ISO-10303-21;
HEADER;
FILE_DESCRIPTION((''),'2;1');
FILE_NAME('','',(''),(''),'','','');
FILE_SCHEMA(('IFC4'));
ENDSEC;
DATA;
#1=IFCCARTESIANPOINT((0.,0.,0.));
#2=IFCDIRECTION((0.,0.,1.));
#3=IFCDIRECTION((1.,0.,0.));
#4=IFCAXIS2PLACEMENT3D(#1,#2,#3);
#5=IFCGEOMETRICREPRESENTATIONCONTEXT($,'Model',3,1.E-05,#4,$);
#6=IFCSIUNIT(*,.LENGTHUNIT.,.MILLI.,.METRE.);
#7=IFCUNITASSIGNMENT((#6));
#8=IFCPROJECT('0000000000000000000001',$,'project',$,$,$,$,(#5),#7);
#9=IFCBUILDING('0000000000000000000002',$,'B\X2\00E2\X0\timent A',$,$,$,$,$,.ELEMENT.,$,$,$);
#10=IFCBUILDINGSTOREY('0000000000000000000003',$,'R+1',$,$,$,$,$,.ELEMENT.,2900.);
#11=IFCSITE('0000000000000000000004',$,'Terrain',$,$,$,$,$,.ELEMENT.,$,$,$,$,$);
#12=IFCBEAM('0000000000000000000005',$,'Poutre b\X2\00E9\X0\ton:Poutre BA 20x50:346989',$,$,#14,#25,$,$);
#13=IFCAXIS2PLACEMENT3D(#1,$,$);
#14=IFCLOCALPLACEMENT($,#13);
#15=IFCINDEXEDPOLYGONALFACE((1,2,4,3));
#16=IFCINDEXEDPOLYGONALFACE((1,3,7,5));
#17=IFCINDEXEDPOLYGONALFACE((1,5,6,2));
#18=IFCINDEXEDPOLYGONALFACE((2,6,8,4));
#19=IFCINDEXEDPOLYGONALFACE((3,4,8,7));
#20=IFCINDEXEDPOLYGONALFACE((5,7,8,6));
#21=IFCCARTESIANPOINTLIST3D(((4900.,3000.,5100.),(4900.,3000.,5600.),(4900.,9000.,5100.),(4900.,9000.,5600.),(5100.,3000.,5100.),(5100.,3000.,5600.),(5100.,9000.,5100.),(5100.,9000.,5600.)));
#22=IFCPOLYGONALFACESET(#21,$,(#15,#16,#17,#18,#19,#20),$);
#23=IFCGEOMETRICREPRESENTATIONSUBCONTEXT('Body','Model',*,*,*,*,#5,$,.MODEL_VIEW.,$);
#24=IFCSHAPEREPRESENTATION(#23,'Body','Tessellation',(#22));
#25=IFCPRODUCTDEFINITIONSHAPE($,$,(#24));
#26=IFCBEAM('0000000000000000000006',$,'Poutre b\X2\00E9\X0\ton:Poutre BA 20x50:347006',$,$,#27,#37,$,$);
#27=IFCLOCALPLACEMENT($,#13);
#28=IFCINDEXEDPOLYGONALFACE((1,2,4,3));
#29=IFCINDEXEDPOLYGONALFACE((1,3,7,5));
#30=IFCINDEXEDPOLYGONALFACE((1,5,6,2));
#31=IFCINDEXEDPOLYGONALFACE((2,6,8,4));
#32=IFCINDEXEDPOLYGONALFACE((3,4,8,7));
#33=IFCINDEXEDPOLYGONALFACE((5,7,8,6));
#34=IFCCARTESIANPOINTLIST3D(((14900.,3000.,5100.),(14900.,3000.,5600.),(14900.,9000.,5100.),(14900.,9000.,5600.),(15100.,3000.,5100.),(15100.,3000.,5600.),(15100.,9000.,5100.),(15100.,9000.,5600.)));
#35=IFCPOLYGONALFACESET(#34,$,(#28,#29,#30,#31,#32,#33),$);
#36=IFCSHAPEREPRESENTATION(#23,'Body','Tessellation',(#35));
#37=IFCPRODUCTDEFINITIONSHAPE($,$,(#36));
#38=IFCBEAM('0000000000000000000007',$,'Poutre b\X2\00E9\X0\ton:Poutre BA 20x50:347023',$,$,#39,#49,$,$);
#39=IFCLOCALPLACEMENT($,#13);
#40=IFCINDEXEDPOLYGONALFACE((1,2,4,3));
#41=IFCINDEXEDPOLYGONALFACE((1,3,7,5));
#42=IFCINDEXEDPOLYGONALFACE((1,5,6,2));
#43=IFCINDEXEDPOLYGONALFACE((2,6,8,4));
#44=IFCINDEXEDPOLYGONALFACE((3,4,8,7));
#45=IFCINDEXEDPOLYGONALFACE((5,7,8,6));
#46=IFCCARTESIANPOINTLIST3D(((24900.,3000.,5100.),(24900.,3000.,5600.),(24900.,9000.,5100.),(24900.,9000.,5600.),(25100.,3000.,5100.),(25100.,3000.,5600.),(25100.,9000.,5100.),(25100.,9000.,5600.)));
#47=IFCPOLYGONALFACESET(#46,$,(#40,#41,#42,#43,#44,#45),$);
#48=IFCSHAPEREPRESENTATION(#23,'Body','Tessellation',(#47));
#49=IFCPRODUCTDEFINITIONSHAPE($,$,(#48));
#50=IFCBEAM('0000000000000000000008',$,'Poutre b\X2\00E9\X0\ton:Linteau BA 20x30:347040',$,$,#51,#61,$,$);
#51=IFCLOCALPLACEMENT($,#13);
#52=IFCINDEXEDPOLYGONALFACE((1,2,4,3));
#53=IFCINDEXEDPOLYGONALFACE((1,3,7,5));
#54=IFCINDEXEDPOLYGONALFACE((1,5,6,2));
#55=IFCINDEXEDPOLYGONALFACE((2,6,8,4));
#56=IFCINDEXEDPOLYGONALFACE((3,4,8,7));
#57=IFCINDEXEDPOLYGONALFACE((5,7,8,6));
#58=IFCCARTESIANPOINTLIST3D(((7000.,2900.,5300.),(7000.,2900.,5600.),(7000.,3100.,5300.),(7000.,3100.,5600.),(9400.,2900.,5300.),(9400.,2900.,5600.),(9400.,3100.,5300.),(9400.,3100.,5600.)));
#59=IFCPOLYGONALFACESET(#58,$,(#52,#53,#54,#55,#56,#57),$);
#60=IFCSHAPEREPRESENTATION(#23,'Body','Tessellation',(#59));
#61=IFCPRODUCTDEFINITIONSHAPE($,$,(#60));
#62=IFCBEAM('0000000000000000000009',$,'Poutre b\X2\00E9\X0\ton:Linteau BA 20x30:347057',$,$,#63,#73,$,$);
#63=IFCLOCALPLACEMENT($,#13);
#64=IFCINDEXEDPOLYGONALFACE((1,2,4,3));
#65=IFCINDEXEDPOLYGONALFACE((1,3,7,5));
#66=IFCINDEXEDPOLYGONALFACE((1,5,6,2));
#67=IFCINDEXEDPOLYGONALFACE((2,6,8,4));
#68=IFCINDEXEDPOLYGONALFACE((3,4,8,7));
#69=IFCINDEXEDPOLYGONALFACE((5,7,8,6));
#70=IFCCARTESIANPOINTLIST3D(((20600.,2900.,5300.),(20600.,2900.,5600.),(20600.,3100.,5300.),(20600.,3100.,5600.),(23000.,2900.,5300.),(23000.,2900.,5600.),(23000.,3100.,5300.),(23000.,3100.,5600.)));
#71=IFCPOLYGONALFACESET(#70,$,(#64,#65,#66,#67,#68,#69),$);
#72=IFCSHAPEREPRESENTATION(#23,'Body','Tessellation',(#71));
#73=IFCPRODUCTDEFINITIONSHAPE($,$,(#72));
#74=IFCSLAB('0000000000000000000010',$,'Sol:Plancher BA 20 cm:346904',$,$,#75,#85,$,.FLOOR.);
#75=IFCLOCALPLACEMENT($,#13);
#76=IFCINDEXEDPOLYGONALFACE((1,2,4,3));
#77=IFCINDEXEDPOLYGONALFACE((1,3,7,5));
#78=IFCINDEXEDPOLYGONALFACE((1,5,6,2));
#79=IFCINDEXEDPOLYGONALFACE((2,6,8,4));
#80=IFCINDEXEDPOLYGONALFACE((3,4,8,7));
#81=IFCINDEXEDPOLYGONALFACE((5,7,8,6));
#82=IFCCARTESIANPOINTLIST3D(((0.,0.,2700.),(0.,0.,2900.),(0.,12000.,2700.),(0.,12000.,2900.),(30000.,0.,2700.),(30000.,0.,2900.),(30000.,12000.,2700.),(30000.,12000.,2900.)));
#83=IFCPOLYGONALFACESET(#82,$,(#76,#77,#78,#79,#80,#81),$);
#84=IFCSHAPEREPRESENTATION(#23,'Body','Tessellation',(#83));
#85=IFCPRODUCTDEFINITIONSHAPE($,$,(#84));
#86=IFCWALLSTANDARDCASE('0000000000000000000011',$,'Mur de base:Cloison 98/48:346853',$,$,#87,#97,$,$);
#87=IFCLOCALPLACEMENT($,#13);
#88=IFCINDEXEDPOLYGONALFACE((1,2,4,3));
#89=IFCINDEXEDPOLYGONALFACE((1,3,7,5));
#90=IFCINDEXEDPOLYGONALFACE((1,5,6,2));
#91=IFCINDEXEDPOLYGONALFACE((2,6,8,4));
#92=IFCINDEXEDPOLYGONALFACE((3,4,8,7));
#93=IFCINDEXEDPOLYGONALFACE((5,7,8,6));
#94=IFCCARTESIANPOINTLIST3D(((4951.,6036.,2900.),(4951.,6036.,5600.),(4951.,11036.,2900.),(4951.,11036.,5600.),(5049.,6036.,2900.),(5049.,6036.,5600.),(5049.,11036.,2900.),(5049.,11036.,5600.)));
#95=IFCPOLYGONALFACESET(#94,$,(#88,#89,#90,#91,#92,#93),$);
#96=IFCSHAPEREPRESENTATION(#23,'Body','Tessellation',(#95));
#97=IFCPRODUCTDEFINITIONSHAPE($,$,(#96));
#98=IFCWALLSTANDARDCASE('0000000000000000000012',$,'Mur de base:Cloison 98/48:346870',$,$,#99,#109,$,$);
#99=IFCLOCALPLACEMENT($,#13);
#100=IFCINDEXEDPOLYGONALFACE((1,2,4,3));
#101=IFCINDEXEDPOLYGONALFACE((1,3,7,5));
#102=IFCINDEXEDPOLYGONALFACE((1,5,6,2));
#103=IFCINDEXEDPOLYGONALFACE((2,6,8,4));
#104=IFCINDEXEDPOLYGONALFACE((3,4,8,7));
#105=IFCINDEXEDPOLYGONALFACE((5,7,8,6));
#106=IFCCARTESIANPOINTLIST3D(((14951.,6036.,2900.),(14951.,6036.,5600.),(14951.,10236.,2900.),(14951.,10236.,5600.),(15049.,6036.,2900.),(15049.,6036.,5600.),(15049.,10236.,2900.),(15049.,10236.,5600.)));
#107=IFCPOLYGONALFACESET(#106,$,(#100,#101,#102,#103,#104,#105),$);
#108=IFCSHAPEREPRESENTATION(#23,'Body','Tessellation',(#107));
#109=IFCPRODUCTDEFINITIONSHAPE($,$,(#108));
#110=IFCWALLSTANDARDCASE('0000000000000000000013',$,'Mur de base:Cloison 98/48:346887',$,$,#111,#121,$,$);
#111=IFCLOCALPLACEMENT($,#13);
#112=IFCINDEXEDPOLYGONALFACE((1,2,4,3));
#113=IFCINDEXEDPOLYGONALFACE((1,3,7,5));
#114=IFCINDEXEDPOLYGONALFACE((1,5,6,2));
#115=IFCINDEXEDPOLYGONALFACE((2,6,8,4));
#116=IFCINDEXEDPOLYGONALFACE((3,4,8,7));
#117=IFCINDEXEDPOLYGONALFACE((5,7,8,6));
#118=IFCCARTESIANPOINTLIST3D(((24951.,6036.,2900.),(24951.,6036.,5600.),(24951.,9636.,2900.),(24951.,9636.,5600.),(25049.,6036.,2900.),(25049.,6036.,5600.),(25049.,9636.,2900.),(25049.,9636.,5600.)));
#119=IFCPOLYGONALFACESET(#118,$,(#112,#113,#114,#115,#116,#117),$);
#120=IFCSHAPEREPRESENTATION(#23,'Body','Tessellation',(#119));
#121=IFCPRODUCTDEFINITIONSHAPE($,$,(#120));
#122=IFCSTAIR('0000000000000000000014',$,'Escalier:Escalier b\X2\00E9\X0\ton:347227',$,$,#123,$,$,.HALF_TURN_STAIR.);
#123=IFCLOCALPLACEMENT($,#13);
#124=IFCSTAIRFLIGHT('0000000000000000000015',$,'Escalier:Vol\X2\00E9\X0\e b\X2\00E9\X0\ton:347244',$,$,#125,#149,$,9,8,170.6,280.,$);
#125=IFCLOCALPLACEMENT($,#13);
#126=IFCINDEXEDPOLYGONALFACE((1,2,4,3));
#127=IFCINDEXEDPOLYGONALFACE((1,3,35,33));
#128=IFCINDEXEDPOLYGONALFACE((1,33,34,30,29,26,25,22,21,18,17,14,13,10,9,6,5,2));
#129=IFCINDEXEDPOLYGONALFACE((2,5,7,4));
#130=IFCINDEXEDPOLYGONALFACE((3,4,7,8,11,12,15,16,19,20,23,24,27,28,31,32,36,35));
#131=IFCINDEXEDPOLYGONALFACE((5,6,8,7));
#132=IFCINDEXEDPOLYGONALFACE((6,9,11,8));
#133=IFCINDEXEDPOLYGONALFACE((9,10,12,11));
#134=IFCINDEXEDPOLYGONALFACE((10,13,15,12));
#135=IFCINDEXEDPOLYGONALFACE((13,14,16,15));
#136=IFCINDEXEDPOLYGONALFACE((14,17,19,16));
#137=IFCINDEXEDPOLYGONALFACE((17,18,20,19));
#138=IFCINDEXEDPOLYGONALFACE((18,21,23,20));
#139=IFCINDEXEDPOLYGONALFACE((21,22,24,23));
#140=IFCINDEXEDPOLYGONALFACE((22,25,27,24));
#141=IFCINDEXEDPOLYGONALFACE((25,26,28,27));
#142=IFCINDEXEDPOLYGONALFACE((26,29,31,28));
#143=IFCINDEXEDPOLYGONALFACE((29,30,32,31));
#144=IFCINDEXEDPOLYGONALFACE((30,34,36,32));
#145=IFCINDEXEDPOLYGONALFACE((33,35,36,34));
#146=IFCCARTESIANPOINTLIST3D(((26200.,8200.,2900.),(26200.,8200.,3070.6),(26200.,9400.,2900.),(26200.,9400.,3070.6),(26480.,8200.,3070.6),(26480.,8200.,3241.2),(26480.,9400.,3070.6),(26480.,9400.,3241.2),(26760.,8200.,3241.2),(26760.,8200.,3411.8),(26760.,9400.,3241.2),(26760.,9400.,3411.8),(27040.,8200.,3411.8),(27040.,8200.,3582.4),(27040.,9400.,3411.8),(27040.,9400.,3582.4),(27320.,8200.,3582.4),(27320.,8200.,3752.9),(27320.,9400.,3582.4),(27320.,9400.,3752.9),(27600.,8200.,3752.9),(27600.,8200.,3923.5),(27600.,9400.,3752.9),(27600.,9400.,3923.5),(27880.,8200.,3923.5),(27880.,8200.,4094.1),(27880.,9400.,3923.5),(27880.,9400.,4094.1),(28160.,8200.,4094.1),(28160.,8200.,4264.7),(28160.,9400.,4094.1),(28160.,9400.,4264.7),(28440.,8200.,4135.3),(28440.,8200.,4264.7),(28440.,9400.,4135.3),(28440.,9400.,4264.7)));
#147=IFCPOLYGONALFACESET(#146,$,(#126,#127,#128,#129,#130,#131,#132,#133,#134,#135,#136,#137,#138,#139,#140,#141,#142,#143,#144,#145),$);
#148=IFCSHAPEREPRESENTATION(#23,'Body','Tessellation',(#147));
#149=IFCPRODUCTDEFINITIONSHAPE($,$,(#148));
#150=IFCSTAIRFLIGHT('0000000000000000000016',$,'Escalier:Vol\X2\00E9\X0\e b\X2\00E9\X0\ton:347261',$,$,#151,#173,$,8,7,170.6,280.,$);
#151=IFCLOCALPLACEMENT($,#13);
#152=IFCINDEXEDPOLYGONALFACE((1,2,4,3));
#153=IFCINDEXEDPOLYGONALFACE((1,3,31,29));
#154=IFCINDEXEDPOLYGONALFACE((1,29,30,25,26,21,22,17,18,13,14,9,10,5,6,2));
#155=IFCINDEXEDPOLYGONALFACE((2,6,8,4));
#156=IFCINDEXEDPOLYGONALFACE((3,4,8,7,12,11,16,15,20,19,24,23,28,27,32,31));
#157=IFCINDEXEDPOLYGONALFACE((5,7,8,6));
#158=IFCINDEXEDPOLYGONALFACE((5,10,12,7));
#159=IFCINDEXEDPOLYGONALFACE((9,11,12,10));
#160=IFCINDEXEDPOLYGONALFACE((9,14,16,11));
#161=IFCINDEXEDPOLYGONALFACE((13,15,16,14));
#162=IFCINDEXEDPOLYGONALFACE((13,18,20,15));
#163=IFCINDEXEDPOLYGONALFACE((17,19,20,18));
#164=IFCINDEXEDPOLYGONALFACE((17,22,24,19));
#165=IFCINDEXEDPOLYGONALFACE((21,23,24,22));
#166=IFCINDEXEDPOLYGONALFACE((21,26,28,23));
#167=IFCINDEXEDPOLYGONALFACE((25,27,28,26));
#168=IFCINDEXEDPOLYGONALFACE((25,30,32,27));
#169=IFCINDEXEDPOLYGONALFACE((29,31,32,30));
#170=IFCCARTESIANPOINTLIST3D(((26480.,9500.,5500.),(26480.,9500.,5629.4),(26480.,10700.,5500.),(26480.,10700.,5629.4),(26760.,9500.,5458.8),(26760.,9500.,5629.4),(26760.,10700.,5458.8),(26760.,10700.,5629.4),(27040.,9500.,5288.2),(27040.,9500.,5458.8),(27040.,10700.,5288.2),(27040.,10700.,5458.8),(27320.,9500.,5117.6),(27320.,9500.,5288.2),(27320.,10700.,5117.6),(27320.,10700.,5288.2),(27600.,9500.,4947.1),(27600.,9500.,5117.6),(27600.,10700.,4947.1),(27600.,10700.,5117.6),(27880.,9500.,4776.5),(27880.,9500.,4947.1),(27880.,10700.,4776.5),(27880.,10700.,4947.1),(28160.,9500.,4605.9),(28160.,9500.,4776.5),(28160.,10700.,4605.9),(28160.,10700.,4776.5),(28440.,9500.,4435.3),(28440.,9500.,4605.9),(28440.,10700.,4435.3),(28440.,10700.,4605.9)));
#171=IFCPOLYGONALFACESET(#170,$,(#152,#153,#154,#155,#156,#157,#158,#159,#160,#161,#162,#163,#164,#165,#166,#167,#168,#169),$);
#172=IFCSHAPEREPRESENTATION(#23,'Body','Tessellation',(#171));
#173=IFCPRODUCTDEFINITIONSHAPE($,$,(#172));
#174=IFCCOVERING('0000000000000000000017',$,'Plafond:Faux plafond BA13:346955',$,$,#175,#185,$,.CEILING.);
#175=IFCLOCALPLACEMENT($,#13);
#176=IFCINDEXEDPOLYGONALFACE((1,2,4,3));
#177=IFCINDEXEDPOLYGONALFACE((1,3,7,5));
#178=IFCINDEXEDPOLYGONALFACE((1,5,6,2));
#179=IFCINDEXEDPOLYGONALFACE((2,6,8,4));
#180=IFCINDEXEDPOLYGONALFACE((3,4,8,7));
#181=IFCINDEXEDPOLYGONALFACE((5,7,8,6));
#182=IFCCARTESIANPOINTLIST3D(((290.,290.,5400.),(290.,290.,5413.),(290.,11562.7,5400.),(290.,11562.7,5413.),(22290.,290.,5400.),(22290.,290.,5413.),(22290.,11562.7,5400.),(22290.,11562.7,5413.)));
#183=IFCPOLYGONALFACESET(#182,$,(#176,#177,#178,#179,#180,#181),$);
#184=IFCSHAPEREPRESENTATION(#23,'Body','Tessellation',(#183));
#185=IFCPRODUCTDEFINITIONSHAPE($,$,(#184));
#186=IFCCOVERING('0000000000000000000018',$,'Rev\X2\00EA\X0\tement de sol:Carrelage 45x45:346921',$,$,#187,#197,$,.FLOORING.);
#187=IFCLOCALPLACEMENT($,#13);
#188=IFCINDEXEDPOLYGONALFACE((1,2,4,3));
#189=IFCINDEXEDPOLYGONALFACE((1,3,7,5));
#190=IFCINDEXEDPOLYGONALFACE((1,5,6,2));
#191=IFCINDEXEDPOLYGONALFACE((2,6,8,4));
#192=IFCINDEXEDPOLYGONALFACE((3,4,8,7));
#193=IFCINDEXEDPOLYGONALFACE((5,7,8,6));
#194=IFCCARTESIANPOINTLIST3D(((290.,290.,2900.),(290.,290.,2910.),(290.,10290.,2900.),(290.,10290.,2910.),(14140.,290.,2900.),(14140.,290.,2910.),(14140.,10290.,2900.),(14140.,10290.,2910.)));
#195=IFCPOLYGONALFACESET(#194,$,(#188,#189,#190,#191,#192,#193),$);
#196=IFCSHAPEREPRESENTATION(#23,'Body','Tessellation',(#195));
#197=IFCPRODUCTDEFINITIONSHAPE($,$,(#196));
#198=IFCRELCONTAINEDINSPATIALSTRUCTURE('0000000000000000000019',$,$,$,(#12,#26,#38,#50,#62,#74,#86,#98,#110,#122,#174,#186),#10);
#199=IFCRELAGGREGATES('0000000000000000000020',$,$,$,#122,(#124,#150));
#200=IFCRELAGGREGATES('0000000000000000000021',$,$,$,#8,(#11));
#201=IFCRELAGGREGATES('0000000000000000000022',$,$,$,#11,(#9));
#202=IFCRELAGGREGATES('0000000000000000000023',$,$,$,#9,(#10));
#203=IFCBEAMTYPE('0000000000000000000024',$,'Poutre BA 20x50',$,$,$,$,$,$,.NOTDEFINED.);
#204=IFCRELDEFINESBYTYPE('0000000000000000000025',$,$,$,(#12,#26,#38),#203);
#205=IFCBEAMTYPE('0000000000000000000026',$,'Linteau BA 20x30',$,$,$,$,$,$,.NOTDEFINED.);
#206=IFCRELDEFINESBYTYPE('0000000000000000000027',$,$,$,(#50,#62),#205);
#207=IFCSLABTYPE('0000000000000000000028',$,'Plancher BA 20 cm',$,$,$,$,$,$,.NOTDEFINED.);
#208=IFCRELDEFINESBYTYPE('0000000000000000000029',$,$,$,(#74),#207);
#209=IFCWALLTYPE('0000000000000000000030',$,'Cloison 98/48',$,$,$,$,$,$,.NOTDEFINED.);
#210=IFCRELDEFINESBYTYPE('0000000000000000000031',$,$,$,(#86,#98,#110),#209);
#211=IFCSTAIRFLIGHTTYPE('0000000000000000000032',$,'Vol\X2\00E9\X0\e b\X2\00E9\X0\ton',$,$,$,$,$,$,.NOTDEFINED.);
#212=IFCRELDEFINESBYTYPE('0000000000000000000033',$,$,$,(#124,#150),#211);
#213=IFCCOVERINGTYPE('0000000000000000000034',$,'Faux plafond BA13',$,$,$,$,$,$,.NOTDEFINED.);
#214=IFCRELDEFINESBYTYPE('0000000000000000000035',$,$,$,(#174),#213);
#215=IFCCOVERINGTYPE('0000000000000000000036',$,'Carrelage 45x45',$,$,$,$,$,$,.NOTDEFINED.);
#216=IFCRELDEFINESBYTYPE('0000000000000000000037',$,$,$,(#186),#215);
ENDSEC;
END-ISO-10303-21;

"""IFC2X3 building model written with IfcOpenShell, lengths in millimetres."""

from ifc_helpers import new_model, si_unit, frame, frame_2d, origin_with_axes, place, context, subcontext, project, spatial, polyline, rectangle, outline, extrude, type_object, element, aggregate, save


model = new_model("IFC2X3")

# Units and contexts
model_context = context("Model", 3, precision=1e-05, world=origin_with_axes())
body_context = subcontext(model_context, "Body", "Model", "MODEL_VIEW")
ifc_project = project(units=[si_unit("LENGTHUNIT", "METRE", prefix="MILLI")], contexts=[model_context])

# Site, building, storey
site = spatial("IfcSite", under=ifc_project, Name="Terrain", CompositionType="ELEMENT")
building = spatial("IfcBuilding", under=site, Name="Bâtiment A", CompositionType="ELEMENT")
storey = spatial("IfcBuildingStorey", under=building, Name="R+1", CompositionType="ELEMENT", Elevation=2900.0)

# Beams
beam_type_1 = type_object("IfcBeamType", Name="Poutre BA 20x50", PredefinedType="NOTDEFINED")
beam_1_placement = place(None, origin_with_axes())
element("IfcBeam", 1, at=beam_1_placement, inside=storey, type_object=beam_type_1, Name="Poutre béton:Poutre BA 20x50:346989", context=body_context, shape_type="SweptSolid", body=[
    extrude(rectangle(XDim=200.0, YDim=6000.0, at=frame_2d((5000.0, 6000.0))), frame((0.0, 0.0, 5100.0), z_axis=(0.0, 0.0, 1.0), x_axis=(1.0, 0.0, 0.0)), (0.0, 0.0, 1.0), 500.0),
])
beam_2_placement = place(None, origin_with_axes())
element("IfcBeam", 2, at=beam_2_placement, inside=storey, type_object=beam_type_1, Name="Poutre béton:Poutre BA 20x50:347006", context=body_context, shape_type="SweptSolid", body=[
    extrude(rectangle(XDim=200.0, YDim=6000.0, at=frame_2d((15000.0, 6000.0))), frame((0.0, 0.0, 5100.0), z_axis=(0.0, 0.0, 1.0), x_axis=(1.0, 0.0, 0.0)), (0.0, 0.0, 1.0), 500.0),
])
beam_3_placement = place(None, origin_with_axes())
element("IfcBeam", 3, at=beam_3_placement, inside=storey, type_object=beam_type_1, Name="Poutre béton:Poutre BA 20x50:347023", context=body_context, shape_type="SweptSolid", body=[
    extrude(rectangle(XDim=200.0, YDim=6000.0, at=frame_2d((25000.0, 6000.0))), frame((0.0, 0.0, 5100.0), z_axis=(0.0, 0.0, 1.0), x_axis=(1.0, 0.0, 0.0)), (0.0, 0.0, 1.0), 500.0),
])
beam_type_2 = type_object("IfcBeamType", Name="Linteau BA 20x30", PredefinedType="NOTDEFINED")
beam_4_placement = place(None, origin_with_axes())
element("IfcBeam", 4, at=beam_4_placement, inside=storey, type_object=beam_type_2, Name="Poutre béton:Linteau BA 20x30:347040", context=body_context, shape_type="SweptSolid", body=[
    extrude(rectangle(XDim=2400.0, YDim=200.0, at=frame_2d((8200.0, 3000.0))), frame((0.0, 0.0, 5300.0), z_axis=(0.0, 0.0, 1.0), x_axis=(1.0, 0.0, 0.0)), (0.0, 0.0, 1.0), 300.0),
])
beam_5_placement = place(None, origin_with_axes())
element("IfcBeam", 5, at=beam_5_placement, inside=storey, type_object=beam_type_2, Name="Poutre béton:Linteau BA 20x30:347057", context=body_context, shape_type="SweptSolid", body=[
    extrude(rectangle(XDim=2400.0, YDim=200.0, at=frame_2d((21800.0, 3000.0))), frame((0.0, 0.0, 5300.0), z_axis=(0.0, 0.0, 1.0), x_axis=(1.0, 0.0, 0.0)), (0.0, 0.0, 1.0), 300.0),
])

# Slab
slab_type = type_object("IfcSlabType", Name="Plancher BA 20 cm", PredefinedType="NOTDEFINED")
slab_placement = place(None, origin_with_axes())
element("IfcSlab", 6, at=slab_placement, inside=storey, type_object=slab_type, Name="Sol:Plancher BA 20 cm:346904", PredefinedType="FLOOR", context=body_context, shape_type="SweptSolid", body=[
    extrude(rectangle(XDim=30000.0, YDim=12000.0, at=frame_2d((15000.0, 6000.0))), frame((0.0, 0.0, 2700.0), z_axis=(0.0, 0.0, 1.0), x_axis=(1.0, 0.0, 0.0)), (0.0, 0.0, 1.0), 200.0),
])

# Walls
wall_type = type_object("IfcWallType", Name="Cloison 98/48", PredefinedType="NOTDEFINED")
wall_1_placement = place(None, origin_with_axes())
element("IfcWallStandardCase", 7, at=wall_1_placement, inside=storey, type_object=wall_type, Name="Mur de base:Cloison 98/48:346853", context=body_context, shape_type="SweptSolid", body=[
    extrude(rectangle(XDim=98.0, YDim=5000.0, at=frame_2d((5000.0, 8536.0))), frame((0.0, 0.0, 2900.0), z_axis=(0.0, 0.0, 1.0), x_axis=(1.0, 0.0, 0.0)), (0.0, 0.0, 1.0), 2700.0),
])
wall_2_placement = place(None, origin_with_axes())
element("IfcWallStandardCase", 8, at=wall_2_placement, inside=storey, type_object=wall_type, Name="Mur de base:Cloison 98/48:346870", context=body_context, shape_type="SweptSolid", body=[
    extrude(rectangle(XDim=98.0, YDim=4200.0, at=frame_2d((15000.0, 8136.0))), frame((0.0, 0.0, 2900.0), z_axis=(0.0, 0.0, 1.0), x_axis=(1.0, 0.0, 0.0)), (0.0, 0.0, 1.0), 2700.0),
])
wall_3_placement = place(None, origin_with_axes())
element("IfcWallStandardCase", 9, at=wall_3_placement, inside=storey, type_object=wall_type, Name="Mur de base:Cloison 98/48:346887", context=body_context, shape_type="SweptSolid", body=[
    extrude(rectangle(XDim=98.0, YDim=3600.0, at=frame_2d((25000.0, 7836.0))), frame((0.0, 0.0, 2900.0), z_axis=(0.0, 0.0, 1.0), x_axis=(1.0, 0.0, 0.0)), (0.0, 0.0, 1.0), 2700.0),
])

# Stair, stair flights
stair = element("IfcStair", 10, inside=storey, Name="Escalier:Escalier béton:347227", ShapeType="HALF_TURN_STAIR")
stair_flight_type = type_object("IfcStairFlightType", Name="Volée béton", PredefinedType="NOTDEFINED")
stair_flight_1_placement = place(None, origin_with_axes())
stair_flight_1 = element("IfcStairFlight", 11, at=stair_flight_1_placement, type_object=stair_flight_type, Name="Escalier:Volée béton:347244", NumberOfRiser=9, NumberOfTreads=8, RiserHeight=170.6, TreadLength=280.0, context=body_context, shape_type="SweptSolid", body=[
    extrude(outline(polyline([(0.0, 0.0), (0.0, 170.6), (280.0, 170.6), (280.0, 341.2), (560.0, 341.2), (560.0, 511.8), (840.0, 511.8), (840.0, 682.4), (1120.0, 682.4), (1120.0, 852.9), (1400.0, 852.9), (1400.0, 1023.5), (1680.0, 1023.5), (1680.0, 1194.1), (1960.0, 1194.1), (1960.0, 1364.7), (2240.0, 1364.7), (2240.0, 1535.3), (2240.0, 1235.3), (0.0, 0.0)])), frame((26200.0, 9400.0, 2900.0), z_axis=(0.0, -1.0, 0.0), x_axis=(1.0, 0.0, 0.0)), (0.0, 0.0, 1.0), 1200.0),
])
stair_flight_2_placement = place(None, origin_with_axes())
stair_flight_2 = element("IfcStairFlight", 12, at=stair_flight_2_placement, type_object=stair_flight_type, Name="Escalier:Volée béton:347261", NumberOfRiser=8, NumberOfTreads=7, RiserHeight=170.6, TreadLength=280.0, context=body_context, shape_type="SweptSolid", body=[
    extrude(outline(polyline([(0.0, 0.0), (0.0, 170.6), (280.0, 170.6), (280.0, 341.2), (560.0, 341.2), (560.0, 511.8), (840.0, 511.8), (840.0, 682.4), (1120.0, 682.4), (1120.0, 852.9), (1400.0, 852.9), (1400.0, 1023.5), (1680.0, 1023.5), (1680.0, 1194.1), (1960.0, 1194.1), (1960.0, 1364.7), (1960.0, 1064.7), (0.0, 0.0)])), frame((28440.0, 9500.0, 4435.3), z_axis=(0.0, 1.0, 0.0), x_axis=(-1.0, 0.0, 0.0)), (0.0, 0.0, 1.0), 1200.0),
])
aggregate(stair, [stair_flight_1, stair_flight_2])

# Coverings
covering_type_1 = type_object("IfcCoveringType", Name="Faux plafond BA13", PredefinedType="NOTDEFINED")
covering_1_placement = place(None, origin_with_axes())
element("IfcCovering", 13, at=covering_1_placement, inside=storey, type_object=covering_type_1, Name="Plafond:Faux plafond BA13:346955", PredefinedType="CEILING", context=body_context, shape_type="SweptSolid", body=[
    extrude(rectangle(XDim=22000.0, YDim=11272.7, at=frame_2d((11290.0, 5926.4))), frame((0.0, 0.0, 5400.0), z_axis=(0.0, 0.0, 1.0), x_axis=(1.0, 0.0, 0.0)), (0.0, 0.0, 1.0), 13.0),
])
covering_type_2 = type_object("IfcCoveringType", Name="Carrelage 45x45", PredefinedType="NOTDEFINED")
covering_2_placement = place(None, origin_with_axes())
element("IfcCovering", 14, at=covering_2_placement, inside=storey, type_object=covering_type_2, Name="Revêtement de sol:Carrelage 45x45:346921", PredefinedType="FLOORING", context=body_context, shape_type="SweptSolid", body=[
    extrude(rectangle(XDim=13850.0, YDim=10000.0, at=frame_2d((7215.0, 5290.0))), frame((0.0, 0.0, 2900.0), z_axis=(0.0, 0.0, 1.0), x_axis=(1.0, 0.0, 0.0)), (0.0, 0.0, 1.0), 10.0),
])

save(model, "model.ifc")
